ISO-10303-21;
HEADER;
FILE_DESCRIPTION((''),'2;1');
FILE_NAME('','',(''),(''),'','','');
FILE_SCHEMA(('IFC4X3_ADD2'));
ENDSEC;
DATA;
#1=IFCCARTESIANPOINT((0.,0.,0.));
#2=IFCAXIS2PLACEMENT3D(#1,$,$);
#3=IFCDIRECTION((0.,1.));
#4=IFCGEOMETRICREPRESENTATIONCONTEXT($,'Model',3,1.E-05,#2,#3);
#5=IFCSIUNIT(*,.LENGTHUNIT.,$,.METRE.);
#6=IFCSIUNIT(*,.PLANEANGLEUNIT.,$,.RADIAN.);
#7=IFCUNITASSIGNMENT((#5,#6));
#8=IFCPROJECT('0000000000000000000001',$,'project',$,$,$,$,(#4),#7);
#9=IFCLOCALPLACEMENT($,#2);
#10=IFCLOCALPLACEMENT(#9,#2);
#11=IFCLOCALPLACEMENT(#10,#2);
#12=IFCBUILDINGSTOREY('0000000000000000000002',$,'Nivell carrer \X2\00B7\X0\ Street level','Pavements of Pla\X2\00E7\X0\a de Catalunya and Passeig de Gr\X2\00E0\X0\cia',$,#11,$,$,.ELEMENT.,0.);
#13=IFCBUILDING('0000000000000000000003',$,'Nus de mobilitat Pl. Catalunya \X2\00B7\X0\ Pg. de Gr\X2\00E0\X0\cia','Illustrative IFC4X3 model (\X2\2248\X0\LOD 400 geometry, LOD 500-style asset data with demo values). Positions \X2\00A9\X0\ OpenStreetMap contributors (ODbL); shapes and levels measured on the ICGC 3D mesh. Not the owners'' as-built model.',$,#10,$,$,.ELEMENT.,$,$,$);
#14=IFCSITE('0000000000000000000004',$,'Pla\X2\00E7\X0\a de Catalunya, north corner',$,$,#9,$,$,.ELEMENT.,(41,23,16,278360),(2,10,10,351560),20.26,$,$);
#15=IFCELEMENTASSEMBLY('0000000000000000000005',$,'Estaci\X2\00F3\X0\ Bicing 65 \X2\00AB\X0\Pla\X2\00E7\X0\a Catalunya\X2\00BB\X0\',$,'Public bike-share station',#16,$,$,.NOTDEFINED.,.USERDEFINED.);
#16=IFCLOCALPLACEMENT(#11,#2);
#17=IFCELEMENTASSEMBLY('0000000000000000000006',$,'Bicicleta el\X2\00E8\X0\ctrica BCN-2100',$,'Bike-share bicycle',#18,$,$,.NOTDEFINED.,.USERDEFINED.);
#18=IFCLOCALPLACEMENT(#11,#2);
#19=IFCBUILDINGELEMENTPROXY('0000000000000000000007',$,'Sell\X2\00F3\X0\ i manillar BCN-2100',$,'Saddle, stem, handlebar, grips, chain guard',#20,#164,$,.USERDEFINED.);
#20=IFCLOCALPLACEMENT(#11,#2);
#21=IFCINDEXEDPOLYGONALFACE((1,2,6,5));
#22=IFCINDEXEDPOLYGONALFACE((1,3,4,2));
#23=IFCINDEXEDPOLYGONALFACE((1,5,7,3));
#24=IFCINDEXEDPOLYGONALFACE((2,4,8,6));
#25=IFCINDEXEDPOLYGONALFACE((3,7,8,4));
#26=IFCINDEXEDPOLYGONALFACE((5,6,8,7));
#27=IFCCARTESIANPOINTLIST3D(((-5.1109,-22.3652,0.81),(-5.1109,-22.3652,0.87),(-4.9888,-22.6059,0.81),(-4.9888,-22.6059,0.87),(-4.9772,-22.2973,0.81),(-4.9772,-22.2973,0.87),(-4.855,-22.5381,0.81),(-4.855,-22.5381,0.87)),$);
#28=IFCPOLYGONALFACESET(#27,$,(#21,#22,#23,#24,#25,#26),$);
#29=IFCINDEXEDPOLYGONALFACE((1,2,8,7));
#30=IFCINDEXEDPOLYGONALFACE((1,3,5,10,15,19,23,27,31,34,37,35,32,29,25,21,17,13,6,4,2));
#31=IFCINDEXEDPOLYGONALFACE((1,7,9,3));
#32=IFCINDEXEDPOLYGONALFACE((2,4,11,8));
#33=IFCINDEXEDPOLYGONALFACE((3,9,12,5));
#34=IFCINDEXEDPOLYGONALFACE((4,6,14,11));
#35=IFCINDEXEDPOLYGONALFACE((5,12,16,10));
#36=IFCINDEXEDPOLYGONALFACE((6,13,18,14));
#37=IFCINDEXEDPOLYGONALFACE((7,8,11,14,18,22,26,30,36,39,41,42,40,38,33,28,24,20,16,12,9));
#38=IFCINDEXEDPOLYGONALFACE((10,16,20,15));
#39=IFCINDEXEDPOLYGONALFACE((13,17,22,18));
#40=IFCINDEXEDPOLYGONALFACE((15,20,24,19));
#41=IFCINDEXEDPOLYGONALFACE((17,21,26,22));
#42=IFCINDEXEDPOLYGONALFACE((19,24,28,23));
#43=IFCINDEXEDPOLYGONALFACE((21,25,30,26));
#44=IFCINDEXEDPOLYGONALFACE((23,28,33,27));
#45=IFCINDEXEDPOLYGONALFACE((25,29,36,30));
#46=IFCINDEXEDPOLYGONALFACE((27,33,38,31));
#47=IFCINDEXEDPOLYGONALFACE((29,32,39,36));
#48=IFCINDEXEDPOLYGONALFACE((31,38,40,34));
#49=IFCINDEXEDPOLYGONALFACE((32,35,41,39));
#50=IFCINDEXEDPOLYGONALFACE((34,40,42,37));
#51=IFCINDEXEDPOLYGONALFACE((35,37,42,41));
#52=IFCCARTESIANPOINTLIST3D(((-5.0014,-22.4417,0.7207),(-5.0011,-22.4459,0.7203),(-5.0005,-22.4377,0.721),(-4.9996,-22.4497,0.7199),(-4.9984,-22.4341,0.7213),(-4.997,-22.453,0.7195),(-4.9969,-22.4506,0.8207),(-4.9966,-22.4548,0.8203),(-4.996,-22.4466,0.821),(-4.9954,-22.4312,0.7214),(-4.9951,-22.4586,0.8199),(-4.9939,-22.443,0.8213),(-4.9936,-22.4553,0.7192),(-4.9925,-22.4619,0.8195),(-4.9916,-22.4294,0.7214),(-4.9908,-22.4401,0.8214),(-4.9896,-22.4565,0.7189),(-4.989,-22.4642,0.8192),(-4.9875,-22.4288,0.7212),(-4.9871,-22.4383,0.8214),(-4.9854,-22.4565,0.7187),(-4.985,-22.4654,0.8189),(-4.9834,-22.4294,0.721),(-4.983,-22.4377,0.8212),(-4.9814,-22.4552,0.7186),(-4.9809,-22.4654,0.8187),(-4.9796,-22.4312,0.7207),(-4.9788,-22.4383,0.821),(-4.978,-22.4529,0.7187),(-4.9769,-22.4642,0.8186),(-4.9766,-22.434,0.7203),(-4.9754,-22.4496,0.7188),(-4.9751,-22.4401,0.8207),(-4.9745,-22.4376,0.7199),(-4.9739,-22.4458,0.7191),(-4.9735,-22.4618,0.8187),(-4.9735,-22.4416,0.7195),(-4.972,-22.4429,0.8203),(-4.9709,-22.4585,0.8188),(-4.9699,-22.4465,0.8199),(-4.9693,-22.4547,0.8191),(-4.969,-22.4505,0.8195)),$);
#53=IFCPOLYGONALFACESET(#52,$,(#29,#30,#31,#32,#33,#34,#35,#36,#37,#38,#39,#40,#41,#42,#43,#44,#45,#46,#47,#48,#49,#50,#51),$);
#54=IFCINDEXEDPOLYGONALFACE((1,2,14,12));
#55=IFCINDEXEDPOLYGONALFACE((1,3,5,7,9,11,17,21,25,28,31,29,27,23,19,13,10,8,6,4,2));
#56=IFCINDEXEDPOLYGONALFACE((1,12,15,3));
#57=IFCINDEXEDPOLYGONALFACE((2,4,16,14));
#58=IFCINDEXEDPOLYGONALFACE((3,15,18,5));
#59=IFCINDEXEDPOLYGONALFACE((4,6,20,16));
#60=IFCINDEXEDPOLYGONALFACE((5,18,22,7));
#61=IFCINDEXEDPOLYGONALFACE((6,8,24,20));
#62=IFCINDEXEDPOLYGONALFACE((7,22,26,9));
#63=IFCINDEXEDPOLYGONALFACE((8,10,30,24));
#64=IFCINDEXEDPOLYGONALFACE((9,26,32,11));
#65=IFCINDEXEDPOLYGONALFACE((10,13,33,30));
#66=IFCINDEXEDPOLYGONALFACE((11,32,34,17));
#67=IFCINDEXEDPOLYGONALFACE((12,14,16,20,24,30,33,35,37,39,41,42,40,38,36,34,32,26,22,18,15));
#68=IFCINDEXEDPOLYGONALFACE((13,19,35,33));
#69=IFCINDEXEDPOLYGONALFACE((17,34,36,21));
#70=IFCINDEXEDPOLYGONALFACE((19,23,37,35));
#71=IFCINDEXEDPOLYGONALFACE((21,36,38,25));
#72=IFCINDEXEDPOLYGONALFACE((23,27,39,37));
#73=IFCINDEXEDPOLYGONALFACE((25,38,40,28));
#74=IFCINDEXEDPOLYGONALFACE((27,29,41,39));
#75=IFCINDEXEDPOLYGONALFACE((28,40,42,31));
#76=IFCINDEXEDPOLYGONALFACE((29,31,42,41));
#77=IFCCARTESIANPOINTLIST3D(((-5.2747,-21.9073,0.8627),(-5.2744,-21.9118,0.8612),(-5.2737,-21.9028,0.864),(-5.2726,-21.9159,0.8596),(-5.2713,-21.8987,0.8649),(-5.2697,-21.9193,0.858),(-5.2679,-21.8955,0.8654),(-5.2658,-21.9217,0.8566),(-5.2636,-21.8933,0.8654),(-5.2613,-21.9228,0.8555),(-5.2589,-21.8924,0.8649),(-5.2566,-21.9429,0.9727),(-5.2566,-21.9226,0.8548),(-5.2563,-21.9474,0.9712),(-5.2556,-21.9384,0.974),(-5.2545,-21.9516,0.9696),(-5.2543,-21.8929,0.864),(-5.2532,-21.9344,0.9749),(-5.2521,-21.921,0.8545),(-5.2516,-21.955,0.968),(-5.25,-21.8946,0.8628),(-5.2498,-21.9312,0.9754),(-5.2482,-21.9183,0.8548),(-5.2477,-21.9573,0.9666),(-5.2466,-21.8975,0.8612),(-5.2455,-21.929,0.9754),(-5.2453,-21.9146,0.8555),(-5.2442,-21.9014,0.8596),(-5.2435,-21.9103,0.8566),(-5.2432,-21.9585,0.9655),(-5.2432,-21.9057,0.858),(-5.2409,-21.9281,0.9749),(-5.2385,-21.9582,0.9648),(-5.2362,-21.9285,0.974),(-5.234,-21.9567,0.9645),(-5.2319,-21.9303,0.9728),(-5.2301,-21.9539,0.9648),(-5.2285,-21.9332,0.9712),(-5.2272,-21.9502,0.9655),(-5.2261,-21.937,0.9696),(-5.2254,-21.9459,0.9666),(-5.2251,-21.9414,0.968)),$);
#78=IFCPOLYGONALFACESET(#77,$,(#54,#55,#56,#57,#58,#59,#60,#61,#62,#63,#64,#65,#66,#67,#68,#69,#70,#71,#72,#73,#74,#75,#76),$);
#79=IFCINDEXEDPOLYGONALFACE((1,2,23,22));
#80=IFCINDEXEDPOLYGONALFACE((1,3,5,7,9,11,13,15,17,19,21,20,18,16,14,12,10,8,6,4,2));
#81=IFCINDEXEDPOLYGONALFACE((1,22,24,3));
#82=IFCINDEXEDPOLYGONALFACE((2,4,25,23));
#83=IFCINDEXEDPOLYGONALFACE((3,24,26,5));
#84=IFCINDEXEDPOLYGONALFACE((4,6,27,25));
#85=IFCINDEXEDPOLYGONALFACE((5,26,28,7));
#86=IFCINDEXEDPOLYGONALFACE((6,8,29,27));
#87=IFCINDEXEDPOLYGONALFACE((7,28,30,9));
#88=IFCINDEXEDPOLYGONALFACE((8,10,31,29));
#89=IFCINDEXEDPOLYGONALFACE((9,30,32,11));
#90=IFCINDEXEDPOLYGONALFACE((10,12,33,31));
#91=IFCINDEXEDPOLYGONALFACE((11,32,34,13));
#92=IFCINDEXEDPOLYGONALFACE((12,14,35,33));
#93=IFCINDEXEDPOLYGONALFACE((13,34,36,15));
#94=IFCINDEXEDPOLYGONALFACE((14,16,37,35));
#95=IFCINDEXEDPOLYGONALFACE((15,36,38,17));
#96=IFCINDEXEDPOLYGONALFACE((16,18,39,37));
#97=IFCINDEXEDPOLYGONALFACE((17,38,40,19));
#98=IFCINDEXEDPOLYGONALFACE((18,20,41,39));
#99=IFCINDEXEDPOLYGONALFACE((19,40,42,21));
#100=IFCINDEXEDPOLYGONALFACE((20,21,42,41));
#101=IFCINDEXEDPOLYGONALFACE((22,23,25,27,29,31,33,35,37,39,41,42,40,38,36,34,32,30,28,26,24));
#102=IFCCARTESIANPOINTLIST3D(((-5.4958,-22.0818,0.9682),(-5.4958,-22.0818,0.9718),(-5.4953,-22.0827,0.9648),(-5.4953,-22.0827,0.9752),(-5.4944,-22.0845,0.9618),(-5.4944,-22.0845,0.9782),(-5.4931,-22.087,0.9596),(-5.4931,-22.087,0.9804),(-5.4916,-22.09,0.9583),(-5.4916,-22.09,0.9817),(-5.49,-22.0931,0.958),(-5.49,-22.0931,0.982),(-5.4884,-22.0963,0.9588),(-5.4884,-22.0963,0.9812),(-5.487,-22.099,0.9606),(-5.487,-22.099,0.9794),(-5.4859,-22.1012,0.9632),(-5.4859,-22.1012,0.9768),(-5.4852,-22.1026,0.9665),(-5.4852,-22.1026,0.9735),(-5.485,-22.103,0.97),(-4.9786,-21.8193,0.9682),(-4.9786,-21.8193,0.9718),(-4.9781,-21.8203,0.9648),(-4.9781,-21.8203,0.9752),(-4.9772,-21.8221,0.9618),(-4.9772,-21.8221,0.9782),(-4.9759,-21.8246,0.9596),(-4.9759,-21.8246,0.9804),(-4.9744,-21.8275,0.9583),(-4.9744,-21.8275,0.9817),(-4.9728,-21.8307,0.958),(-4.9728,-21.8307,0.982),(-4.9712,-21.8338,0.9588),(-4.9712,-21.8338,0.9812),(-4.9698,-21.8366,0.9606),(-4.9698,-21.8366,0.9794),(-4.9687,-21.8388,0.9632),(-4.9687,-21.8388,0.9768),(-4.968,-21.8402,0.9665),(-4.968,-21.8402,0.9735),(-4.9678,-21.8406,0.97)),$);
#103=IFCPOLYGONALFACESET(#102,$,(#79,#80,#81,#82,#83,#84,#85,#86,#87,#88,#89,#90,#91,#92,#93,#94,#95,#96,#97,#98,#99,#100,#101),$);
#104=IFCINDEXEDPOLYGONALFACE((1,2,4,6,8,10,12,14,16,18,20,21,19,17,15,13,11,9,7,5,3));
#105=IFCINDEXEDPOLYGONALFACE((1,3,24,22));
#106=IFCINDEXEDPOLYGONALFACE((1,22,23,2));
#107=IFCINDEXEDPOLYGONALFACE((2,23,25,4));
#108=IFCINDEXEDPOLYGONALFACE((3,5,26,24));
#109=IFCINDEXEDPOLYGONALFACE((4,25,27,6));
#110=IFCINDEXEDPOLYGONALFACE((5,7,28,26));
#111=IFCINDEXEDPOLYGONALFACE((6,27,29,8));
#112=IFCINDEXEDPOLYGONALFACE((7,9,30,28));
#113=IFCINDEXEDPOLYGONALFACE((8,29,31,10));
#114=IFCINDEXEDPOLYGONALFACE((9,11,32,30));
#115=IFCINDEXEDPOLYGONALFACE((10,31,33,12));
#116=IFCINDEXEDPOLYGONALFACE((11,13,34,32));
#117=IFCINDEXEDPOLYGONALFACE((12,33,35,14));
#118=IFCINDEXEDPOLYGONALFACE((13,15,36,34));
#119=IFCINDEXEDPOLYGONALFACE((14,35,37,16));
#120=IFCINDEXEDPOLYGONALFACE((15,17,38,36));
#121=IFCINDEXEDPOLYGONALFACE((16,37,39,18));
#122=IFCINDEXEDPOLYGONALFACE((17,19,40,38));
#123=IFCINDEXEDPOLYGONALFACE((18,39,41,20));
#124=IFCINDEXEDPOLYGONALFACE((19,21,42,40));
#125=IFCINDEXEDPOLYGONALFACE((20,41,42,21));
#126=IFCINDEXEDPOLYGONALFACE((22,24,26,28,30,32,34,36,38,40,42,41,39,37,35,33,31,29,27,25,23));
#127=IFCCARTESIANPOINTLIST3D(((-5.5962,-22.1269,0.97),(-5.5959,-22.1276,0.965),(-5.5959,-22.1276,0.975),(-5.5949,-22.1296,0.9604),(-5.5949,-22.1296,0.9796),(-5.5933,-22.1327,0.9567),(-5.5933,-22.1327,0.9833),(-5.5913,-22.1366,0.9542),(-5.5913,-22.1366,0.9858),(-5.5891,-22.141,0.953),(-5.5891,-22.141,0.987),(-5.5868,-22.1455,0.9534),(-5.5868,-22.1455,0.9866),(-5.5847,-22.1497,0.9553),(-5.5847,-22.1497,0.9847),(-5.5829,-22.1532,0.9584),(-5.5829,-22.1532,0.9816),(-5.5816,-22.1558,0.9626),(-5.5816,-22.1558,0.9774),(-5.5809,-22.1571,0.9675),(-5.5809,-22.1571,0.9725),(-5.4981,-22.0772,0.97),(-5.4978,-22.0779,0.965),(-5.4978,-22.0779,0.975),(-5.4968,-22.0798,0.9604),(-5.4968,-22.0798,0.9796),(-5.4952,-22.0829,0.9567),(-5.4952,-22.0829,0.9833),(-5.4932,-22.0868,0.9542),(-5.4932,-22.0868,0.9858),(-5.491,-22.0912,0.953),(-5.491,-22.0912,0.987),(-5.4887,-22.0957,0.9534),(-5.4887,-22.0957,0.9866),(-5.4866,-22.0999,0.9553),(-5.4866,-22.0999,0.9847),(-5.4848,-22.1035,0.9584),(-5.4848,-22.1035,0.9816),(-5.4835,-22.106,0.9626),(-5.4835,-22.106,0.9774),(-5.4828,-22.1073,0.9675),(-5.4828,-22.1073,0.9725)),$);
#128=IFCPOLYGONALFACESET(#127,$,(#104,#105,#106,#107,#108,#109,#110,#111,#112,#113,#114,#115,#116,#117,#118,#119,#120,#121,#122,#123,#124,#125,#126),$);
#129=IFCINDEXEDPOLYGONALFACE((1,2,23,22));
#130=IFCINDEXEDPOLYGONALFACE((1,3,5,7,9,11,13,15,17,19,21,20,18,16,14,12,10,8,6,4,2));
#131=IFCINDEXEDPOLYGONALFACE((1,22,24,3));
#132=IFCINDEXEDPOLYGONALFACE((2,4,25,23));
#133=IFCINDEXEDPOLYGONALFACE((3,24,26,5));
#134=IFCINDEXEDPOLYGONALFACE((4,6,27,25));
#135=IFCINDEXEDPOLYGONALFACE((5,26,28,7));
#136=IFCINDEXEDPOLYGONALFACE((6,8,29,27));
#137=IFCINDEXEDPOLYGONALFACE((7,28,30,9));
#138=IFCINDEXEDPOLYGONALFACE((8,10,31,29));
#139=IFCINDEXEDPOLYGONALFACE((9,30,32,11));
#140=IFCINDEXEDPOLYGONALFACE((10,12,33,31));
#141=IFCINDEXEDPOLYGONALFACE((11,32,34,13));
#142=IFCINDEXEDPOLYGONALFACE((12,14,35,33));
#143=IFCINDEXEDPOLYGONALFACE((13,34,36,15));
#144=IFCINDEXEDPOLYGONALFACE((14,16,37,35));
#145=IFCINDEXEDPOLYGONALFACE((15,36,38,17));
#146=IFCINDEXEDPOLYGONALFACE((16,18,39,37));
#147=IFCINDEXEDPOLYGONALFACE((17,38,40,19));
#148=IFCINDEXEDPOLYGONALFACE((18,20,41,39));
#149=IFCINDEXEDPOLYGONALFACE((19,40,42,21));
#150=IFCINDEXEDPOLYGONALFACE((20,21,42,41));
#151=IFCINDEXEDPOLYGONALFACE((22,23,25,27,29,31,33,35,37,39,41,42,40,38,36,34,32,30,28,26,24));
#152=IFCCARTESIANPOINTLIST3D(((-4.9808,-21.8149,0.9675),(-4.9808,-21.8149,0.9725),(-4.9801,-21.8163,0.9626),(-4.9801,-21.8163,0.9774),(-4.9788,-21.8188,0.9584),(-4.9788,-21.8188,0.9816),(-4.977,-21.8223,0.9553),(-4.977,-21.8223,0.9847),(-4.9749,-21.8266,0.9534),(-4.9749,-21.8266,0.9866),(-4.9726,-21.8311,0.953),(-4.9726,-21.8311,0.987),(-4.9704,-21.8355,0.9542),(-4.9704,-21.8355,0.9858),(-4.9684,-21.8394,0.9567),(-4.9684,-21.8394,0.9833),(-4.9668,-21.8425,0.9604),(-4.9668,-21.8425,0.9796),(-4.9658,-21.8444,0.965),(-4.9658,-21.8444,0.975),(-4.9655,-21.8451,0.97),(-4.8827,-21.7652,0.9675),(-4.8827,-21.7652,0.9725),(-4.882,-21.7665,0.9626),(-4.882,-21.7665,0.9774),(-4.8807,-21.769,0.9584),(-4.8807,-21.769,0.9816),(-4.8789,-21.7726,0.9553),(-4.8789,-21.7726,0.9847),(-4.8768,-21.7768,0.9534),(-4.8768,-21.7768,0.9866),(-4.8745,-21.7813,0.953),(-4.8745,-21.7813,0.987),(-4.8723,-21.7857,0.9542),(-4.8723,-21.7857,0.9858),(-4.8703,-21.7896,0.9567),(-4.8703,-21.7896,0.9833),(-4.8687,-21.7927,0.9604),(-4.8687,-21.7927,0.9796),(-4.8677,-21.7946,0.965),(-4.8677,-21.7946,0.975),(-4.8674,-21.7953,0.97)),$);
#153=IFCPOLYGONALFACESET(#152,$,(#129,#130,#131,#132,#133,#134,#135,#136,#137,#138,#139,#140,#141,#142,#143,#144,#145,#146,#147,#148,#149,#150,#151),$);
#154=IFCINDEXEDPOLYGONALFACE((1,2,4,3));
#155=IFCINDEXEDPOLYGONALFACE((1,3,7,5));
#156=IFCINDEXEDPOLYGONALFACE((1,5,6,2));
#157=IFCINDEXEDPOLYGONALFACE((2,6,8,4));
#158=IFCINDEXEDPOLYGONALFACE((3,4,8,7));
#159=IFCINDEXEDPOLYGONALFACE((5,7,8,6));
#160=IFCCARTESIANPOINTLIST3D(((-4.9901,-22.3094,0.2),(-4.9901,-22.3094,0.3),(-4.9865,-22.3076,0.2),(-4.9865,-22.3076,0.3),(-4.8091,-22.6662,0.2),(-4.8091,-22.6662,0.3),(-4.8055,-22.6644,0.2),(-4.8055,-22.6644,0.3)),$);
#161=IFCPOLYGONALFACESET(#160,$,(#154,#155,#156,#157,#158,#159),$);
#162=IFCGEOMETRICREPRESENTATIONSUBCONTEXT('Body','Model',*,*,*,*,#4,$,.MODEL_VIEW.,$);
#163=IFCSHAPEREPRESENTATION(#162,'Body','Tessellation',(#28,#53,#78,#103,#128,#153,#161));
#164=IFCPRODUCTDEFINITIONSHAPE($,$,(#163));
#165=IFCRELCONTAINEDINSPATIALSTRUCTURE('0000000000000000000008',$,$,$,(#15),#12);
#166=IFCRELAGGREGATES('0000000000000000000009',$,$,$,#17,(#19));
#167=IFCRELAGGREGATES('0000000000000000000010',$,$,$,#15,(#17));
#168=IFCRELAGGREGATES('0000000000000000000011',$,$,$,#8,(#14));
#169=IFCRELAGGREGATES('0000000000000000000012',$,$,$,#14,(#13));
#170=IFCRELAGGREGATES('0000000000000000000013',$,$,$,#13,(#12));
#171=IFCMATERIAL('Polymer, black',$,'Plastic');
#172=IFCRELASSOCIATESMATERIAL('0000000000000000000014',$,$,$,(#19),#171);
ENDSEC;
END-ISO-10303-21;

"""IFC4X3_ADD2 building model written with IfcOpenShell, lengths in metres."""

from ifc_helpers import new_model, si_unit, direction, frame, origin, origin_2d_with_axis, place, context, subcontext, project, spatial, rectangle, circle, extrude, material, element, aggregate, save


model = new_model("IFC4X3_ADD2")

# Units and contexts
model_context = context("Model", 3, precision=1e-05, world=origin(), true_north=direction((0.0, 1.0)))
body_context = subcontext(model_context, "Body", "Model", "MODEL_VIEW")
ifc_project = project(units=[si_unit("LENGTHUNIT", "METRE"), si_unit("PLANEANGLEUNIT", "RADIAN")], contexts=[model_context])

# Site, building, storey
site_placement = place(None, origin())
site = spatial("IfcSite", under=ifc_project, at=site_placement, Name="Plaça de Catalunya, north corner", CompositionType="ELEMENT", RefLatitude=(41, 23, 16, 278360), RefLongitude=(2, 10, 10, 351560), RefElevation=20.26)
building_placement = place(site_placement, origin())
building = spatial("IfcBuilding", under=site, at=building_placement, Name="Nus de mobilitat Pl. Catalunya · Pg. de Gràcia", Description="Illustrative IFC4X3 model (≈LOD 400 geometry, LOD 500-style asset data with demo values). Positions © OpenStreetMap contributors (ODbL); shapes and levels measured on the ICGC 3D mesh. Not the owners' as-built model.", CompositionType="ELEMENT")
storey_placement = place(building_placement, origin())
storey = spatial("IfcBuildingStorey", under=building, at=storey_placement, Name="Nivell carrer · Street level", Description="Pavements of Plaça de Catalunya and Passeig de Gràcia", CompositionType="ELEMENT", Elevation=0.0)

# Element assemblies, building element proxy
assembly_1_placement = place(building_placement, origin())
assembly_1 = element("IfcElementAssembly", 1, at=assembly_1_placement, inside=storey, Name="Estació Bicing 65 «Plaça Catalunya»", ObjectType="Public bike-share station", AssemblyPlace="NOTDEFINED", PredefinedType="USERDEFINED")
assembly_2_placement = place(building_placement, origin())
assembly_2 = element("IfcElementAssembly", 2, at=assembly_2_placement, Name="Bicicleta elèctrica BCN-2100", ObjectType="Bike-share bicycle", AssemblyPlace="NOTDEFINED", PredefinedType="USERDEFINED")
ifc_material_1 = material(Name="Polymer, black", Category="Plastic")
proxy_1_placement = place(building_placement, origin())
proxy_1 = element("IfcBuildingElementProxy", 3, at=proxy_1_placement, material=ifc_material_1, Name="Selló i manillar BCN-2100", ObjectType="Saddle, stem, handlebar, grips, chain guard", PredefinedType="USERDEFINED", context=body_context, shape_type="SweptSolid", body=[
    extrude(rectangle(XDim=0.27, YDim=0.15, at=origin_2d_with_axis()), frame((-4.983, -22.4516, 0.87), z_axis=(0.0, 0.0, -1.0), x_axis=(-0.452435, 0.891798, 0.0)), (0.0, 0.0, 1.0), 0.06),
    extrude(circle(Radius=0.014, at=origin_2d_with_axis()), frame((-4.9875, -22.4427, 0.72), z_axis=(0.045019, -0.088737, 0.995037), x_axis=(0.0, 0.996047, 0.088827)), (0.0, 0.0, 1.0), 0.1005),
    extrude(circle(Radius=0.016, at=origin_2d_with_axis()), frame((-5.2589, -21.9076, 0.86), z_axis=(0.154616, -0.304766, 0.939793), x_axis=(0.0, 0.951232, 0.308475)), (0.0, 0.0, 1.0), 0.117),
    extrude(circle(Radius=0.012, at=origin_2d_with_axis()), frame((-5.4904, -22.0923, 0.97), z_axis=(0.891798, 0.452435, 0.0), x_axis=(0.452435, -0.891798, 0.0)), (0.0, 0.0, 1.0), 0.58),
    extrude(circle(Radius=0.017, at=origin_2d_with_axis()), frame((-5.4904, -22.0923, 0.97), z_axis=(-0.891798, -0.452435, 0.0), x_axis=(-0.452435, 0.891798, 0.0)), (0.0, 0.0, 1.0), 0.11),
    extrude(circle(Radius=0.017, at=origin_2d_with_axis()), frame((-4.9732, -21.8299, 0.97), z_axis=(0.891798, 0.452435, 0.0), x_axis=(0.452435, -0.891798, 0.0)), (0.0, 0.0, 1.0), 0.11),
    extrude(rectangle(XDim=0.4, YDim=0.1, at=origin_2d_with_axis()), frame((-4.8996, -22.4878, 0.25), z_axis=(0.891798, 0.452435, 0.0), x_axis=(-0.452435, 0.891798, 0.0)), (0.0, 0.0, 1.0), 0.004),
])
aggregate(assembly_2, [proxy_1])
aggregate(assembly_1, [assembly_2])

save(model, "model.ifc")
